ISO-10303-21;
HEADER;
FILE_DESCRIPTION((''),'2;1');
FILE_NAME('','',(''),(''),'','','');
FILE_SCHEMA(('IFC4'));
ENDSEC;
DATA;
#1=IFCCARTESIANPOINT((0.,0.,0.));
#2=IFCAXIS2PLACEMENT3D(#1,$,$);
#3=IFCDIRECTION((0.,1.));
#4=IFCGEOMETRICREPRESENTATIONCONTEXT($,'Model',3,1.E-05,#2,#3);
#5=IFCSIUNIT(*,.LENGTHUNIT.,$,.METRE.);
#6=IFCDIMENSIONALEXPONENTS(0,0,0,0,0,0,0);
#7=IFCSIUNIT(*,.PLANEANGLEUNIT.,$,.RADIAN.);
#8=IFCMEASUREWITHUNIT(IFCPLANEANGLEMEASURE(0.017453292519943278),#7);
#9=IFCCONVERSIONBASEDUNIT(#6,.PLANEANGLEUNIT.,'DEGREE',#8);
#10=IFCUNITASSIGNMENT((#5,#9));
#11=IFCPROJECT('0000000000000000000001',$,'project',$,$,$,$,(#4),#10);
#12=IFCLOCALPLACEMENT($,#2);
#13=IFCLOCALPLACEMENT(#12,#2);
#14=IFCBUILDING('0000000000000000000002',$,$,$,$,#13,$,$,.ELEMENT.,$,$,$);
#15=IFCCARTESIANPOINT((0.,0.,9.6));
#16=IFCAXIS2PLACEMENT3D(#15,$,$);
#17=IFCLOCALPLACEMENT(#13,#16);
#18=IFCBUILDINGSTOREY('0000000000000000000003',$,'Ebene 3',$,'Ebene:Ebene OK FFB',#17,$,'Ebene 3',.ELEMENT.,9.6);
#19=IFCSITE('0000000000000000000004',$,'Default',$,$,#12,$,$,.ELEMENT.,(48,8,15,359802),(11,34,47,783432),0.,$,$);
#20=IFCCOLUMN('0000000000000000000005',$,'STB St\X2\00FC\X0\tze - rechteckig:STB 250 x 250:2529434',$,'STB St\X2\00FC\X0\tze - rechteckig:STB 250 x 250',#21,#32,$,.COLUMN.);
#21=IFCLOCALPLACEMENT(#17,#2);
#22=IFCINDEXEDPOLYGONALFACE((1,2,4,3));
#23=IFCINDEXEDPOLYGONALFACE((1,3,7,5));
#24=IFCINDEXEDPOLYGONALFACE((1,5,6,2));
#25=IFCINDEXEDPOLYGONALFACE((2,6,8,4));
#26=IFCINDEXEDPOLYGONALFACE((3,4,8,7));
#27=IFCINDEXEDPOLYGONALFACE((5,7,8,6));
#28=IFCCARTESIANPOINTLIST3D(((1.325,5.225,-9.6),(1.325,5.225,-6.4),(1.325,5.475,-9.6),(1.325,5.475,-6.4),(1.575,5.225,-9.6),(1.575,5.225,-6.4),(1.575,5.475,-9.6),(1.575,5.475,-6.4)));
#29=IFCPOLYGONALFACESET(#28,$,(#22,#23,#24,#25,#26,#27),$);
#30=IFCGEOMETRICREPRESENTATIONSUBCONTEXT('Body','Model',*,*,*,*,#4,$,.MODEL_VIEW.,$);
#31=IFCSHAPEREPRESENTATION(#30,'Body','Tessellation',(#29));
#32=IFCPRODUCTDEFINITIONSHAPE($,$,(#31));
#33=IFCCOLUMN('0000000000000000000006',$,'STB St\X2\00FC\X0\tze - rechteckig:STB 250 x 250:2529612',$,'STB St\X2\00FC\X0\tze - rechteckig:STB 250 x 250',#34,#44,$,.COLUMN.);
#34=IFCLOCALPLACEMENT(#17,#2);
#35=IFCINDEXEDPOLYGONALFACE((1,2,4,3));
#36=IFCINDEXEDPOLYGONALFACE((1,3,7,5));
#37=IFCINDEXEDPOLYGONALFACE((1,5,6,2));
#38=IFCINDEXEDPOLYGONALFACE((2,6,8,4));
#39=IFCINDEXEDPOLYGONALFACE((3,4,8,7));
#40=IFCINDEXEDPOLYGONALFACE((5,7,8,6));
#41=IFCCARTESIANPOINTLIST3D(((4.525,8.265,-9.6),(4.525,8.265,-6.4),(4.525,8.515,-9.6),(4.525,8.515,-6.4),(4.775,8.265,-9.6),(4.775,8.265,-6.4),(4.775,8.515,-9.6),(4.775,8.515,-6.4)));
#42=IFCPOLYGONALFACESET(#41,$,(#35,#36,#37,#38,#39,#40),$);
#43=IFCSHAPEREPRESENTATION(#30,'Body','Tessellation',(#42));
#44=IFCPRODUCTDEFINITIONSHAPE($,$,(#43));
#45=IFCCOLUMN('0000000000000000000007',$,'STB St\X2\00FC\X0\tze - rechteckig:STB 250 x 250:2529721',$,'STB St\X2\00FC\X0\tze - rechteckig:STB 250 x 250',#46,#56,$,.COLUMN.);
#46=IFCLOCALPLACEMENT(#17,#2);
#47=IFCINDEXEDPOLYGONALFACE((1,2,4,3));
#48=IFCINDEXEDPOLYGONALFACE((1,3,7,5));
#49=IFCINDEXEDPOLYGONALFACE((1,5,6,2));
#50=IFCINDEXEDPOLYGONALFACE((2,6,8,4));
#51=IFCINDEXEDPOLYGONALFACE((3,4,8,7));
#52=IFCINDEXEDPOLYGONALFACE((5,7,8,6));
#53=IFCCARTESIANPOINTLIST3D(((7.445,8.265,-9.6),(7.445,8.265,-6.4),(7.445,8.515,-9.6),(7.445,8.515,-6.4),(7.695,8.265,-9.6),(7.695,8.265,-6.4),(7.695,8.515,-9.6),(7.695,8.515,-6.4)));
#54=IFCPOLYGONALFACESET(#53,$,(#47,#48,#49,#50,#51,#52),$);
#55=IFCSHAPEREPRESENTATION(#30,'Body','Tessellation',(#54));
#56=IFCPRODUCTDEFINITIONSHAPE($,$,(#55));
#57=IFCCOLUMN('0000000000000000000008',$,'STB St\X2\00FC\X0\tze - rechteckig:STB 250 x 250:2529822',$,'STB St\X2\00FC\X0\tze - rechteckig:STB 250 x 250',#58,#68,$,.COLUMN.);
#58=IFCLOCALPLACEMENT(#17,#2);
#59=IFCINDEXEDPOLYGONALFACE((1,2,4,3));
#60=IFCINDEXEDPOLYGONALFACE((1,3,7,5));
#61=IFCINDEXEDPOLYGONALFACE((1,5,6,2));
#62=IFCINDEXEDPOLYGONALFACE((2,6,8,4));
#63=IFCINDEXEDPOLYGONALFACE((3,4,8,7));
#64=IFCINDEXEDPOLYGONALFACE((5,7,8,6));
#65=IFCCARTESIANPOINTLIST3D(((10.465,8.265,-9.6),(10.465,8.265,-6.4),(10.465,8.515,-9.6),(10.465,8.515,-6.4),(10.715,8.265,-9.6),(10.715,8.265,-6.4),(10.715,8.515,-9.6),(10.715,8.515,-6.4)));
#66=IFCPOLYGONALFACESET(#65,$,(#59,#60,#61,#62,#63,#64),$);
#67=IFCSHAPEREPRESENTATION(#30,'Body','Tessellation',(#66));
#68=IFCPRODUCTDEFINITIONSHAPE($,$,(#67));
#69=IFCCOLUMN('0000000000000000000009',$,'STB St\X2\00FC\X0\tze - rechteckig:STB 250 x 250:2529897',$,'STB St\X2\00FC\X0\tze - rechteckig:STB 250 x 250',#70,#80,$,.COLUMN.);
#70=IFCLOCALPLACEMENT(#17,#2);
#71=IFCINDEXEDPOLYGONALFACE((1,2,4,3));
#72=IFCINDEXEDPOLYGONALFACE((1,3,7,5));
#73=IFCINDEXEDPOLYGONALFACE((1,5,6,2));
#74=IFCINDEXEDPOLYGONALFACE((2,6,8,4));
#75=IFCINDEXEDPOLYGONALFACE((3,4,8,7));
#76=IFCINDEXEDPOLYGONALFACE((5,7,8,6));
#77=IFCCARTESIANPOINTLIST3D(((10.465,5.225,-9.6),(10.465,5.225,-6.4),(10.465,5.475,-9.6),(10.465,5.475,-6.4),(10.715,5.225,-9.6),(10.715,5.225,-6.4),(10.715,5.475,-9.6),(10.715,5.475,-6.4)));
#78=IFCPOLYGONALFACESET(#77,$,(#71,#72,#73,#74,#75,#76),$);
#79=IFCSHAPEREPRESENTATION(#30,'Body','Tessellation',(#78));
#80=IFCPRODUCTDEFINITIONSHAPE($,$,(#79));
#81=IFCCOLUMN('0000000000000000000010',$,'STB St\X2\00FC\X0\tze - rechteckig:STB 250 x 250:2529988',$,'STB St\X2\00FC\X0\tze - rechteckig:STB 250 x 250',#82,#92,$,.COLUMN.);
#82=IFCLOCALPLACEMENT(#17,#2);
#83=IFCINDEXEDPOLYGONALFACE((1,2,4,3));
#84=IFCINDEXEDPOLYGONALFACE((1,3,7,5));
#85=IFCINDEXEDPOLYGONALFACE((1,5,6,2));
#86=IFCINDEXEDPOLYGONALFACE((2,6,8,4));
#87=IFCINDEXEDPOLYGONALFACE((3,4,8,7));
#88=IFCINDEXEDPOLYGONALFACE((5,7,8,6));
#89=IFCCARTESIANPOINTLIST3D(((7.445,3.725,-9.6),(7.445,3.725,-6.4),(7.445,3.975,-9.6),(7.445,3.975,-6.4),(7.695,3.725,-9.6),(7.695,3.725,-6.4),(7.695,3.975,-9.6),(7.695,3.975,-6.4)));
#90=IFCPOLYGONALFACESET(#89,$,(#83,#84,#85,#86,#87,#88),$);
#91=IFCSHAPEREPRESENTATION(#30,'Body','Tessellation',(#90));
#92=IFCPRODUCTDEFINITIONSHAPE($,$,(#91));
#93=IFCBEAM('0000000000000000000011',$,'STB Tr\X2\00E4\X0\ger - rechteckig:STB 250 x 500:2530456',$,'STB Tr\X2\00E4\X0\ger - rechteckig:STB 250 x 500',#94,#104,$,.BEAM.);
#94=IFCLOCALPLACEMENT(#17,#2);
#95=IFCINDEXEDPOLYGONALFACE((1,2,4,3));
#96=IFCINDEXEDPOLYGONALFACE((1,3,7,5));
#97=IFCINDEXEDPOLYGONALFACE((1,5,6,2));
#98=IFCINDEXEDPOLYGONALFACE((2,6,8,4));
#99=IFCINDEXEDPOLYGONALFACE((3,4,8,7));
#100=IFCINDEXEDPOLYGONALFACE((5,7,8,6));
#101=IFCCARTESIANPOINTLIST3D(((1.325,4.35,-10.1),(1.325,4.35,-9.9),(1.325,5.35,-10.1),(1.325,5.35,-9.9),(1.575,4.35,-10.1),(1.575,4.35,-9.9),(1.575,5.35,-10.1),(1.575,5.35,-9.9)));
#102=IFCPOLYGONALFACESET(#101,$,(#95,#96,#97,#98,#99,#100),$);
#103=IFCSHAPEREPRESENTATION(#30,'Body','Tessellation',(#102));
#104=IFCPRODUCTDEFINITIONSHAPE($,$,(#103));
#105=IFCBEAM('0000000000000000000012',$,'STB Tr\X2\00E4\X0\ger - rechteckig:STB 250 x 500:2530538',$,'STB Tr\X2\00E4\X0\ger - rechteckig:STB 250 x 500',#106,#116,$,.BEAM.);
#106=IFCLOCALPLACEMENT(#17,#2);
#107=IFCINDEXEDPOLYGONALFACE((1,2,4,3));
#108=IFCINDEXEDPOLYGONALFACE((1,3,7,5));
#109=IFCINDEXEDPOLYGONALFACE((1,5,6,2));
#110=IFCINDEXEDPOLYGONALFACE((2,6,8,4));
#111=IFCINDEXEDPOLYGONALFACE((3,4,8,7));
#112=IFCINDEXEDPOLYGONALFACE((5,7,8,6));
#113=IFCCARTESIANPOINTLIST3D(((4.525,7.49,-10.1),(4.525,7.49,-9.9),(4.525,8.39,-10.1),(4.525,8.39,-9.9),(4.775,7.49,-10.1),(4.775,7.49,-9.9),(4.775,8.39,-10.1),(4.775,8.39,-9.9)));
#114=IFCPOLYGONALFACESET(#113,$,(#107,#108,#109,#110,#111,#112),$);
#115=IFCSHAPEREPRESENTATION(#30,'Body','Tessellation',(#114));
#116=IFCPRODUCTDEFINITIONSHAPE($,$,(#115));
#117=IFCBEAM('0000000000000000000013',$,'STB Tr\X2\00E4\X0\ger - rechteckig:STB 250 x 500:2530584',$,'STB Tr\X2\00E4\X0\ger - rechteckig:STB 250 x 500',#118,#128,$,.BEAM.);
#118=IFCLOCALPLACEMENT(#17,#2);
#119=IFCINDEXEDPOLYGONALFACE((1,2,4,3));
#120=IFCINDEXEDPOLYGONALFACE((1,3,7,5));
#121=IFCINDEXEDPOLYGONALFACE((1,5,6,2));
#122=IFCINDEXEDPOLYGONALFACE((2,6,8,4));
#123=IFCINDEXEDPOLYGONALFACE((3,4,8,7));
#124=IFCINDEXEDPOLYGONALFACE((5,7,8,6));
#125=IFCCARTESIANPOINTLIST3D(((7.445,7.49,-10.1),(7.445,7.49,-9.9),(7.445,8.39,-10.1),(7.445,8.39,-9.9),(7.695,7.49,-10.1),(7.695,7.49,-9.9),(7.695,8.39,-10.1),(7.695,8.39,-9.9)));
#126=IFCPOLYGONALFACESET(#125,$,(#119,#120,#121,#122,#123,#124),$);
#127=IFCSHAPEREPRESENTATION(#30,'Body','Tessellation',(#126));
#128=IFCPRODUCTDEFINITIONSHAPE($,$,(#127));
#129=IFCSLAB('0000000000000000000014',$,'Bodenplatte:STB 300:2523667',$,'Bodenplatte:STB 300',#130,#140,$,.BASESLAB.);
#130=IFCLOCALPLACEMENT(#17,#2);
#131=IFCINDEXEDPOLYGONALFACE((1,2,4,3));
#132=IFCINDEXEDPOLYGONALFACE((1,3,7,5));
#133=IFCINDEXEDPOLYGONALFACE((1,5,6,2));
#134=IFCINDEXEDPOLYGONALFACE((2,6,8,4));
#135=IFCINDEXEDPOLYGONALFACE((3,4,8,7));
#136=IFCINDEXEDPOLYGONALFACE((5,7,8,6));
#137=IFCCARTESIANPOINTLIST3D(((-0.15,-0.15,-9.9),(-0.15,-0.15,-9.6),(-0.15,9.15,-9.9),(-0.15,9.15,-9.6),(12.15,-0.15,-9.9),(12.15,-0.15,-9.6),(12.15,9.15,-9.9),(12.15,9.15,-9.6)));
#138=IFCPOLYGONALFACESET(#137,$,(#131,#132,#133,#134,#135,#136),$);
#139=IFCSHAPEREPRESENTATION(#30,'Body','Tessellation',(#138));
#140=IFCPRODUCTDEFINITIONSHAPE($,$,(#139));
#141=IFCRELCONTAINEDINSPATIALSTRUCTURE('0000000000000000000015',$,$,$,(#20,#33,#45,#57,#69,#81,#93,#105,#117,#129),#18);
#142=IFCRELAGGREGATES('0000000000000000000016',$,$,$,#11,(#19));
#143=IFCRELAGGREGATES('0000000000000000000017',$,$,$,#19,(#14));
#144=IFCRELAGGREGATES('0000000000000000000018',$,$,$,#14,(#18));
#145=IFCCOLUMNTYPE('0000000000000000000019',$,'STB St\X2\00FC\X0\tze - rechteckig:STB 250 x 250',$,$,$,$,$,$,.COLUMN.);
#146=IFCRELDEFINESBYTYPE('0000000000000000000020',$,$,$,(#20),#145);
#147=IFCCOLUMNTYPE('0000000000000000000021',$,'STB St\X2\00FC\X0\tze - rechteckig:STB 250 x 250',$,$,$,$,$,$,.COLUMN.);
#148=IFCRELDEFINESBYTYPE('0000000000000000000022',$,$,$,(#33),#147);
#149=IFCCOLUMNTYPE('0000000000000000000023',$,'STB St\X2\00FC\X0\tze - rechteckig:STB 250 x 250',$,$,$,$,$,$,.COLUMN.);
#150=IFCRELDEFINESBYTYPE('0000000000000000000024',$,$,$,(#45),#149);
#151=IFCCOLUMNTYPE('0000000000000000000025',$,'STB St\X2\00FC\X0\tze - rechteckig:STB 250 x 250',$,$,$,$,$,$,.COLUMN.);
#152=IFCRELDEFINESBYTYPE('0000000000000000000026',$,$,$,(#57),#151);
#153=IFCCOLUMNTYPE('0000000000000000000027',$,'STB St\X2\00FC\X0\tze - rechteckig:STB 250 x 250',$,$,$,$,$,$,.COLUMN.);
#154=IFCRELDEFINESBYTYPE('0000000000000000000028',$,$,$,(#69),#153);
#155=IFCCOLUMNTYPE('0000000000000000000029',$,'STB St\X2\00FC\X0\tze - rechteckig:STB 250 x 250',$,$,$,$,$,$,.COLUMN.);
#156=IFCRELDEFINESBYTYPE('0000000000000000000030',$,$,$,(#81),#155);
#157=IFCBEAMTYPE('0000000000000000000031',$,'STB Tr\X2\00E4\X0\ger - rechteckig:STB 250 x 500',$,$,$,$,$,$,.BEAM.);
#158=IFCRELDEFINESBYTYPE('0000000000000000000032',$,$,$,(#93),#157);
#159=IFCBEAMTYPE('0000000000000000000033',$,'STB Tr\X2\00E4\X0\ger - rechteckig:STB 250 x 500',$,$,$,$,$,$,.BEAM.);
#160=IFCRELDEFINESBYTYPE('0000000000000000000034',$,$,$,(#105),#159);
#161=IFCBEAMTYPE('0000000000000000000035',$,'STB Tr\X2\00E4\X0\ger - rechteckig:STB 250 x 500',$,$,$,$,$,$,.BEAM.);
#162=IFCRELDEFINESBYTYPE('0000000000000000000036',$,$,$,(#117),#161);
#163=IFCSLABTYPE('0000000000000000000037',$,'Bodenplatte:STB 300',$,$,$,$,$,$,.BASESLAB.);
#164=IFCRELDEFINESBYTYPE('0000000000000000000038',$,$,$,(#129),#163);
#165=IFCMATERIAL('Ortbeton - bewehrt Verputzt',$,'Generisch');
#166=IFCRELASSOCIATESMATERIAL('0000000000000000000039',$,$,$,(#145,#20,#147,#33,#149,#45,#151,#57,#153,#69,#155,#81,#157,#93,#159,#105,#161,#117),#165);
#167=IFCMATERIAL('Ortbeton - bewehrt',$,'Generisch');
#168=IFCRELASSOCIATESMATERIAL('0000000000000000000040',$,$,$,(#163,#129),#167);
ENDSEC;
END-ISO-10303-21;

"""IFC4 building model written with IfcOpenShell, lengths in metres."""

from ifc_helpers import new_model, entity, si_unit, converted_unit, direction, frame, origin, place, context, subcontext, project, spatial, indexed_curve, outline, extrude, source, transform, mapped, material, type_object, type_shapes, element, save


model = new_model("IFC4")

# Units and contexts
model_context = context("Model", 3, precision=1e-05, world=origin(), true_north=direction((0.0, 1.0)))
body_context = subcontext(model_context, "Body", "Model", "MODEL_VIEW")
ifc_project = project(units=[si_unit("LENGTHUNIT", "METRE"), converted_unit("PLANEANGLEUNIT", "DEGREE", entity("IfcPlaneAngleMeasure", 0.017453292519943278), si_unit("PLANEANGLEUNIT", "RADIAN"), dimensions=[0, 0, 0, 0, 0, 0, 0])], contexts=[model_context])

# Site, building, storey
site_placement = place(None, origin())
site = spatial("IfcSite", under=ifc_project, at=site_placement, Name="Default", CompositionType="ELEMENT", RefLatitude=(48, 8, 15, 359802), RefLongitude=(11, 34, 47, 783432), RefElevation=0.0)
building_placement = place(site_placement, origin())
building = spatial("IfcBuilding", under=site, at=building_placement, CompositionType="ELEMENT")
storey_placement = place(building_placement, frame((0.0, 0.0, 9.6)))
storey = spatial("IfcBuildingStorey", under=building, at=storey_placement, Name="Ebene 3", ObjectType="Ebene:Ebene OK FFB", LongName="Ebene 3", CompositionType="ELEMENT", Elevation=9.6)

# Columns
ifc_material_1 = material(Name="Ortbeton - bewehrt Verputzt", Category="Generisch")
column_type_1 = type_object("IfcColumnType", Name="STB Stütze - rechteckig:STB 250 x 250", PredefinedType="COLUMN", material=ifc_material_1)
shared_shape_1 = source(origin(), body_context, "Body", "SweptSolid", [
    extrude(outline(indexed_curve([(-0.125, -0.125), (0.125, -0.125), (0.125, 0.125), (-0.125, 0.125), (-0.125, -0.125)], self_intersect=False)), frame((1.45, 5.35, 0.0), z_axis=(0.0, 0.0, 1.0), x_axis=(-1.0, 0.0, 0.0)), (0.0, 0.0, 1.0), 3.2),
])
type_shapes(column_type_1, [shared_shape_1])
column_1_placement = place(storey_placement, frame((0.0, 0.0, -9.6)))
element("IfcColumn", 1, at=column_1_placement, inside=storey, type_object=column_type_1, material=ifc_material_1, Name="STB Stütze - rechteckig:STB 250 x 250:2529434", ObjectType="STB Stütze - rechteckig:STB 250 x 250", PredefinedType="COLUMN", context=body_context, shape_type="MappedRepresentation", body=[
    mapped(shared_shape_1, transform((0.0, 0.0, 0.0), scale=1.0)),
])
column_type_2 = type_object("IfcColumnType", Name="STB Stütze - rechteckig:STB 250 x 250", PredefinedType="COLUMN", material=ifc_material_1)
shared_shape_2 = source(origin(), body_context, "Body", "SweptSolid", [
    extrude(outline(indexed_curve([(-0.125, -0.125), (0.125, -0.125), (0.125, 0.125), (-0.125, 0.125), (-0.125, -0.125)], self_intersect=False)), frame((4.65, 8.39, 0.0), z_axis=(0.0, 0.0, 1.0), x_axis=(-1.0, 0.0, 0.0)), (0.0, 0.0, 1.0), 3.2),
])
type_shapes(column_type_2, [shared_shape_2])
column_2_placement = place(storey_placement, frame((0.0, 0.0, -9.6)))
element("IfcColumn", 2, at=column_2_placement, inside=storey, type_object=column_type_2, material=ifc_material_1, Name="STB Stütze - rechteckig:STB 250 x 250:2529612", ObjectType="STB Stütze - rechteckig:STB 250 x 250", PredefinedType="COLUMN", context=body_context, shape_type="MappedRepresentation", body=[
    mapped(shared_shape_2, transform((0.0, 0.0, 0.0), scale=1.0)),
])
column_type_3 = type_object("IfcColumnType", Name="STB Stütze - rechteckig:STB 250 x 250", PredefinedType="COLUMN", material=ifc_material_1)
shared_shape_3 = source(origin(), body_context, "Body", "SweptSolid", [
    extrude(outline(indexed_curve([(-0.125, -0.125), (0.125, -0.125), (0.125, 0.125), (-0.125, 0.125), (-0.125, -0.125)], self_intersect=False)), frame((7.57, 8.39, 0.0), z_axis=(0.0, 0.0, 1.0), x_axis=(-1.0, 0.0, 0.0)), (0.0, 0.0, 1.0), 3.2),
])
type_shapes(column_type_3, [shared_shape_3])
column_3_placement = place(storey_placement, frame((0.0, 0.0, -9.6)))
element("IfcColumn", 3, at=column_3_placement, inside=storey, type_object=column_type_3, material=ifc_material_1, Name="STB Stütze - rechteckig:STB 250 x 250:2529721", ObjectType="STB Stütze - rechteckig:STB 250 x 250", PredefinedType="COLUMN", context=body_context, shape_type="MappedRepresentation", body=[
    mapped(shared_shape_3, transform((0.0, 0.0, 0.0), scale=1.0)),
])
column_type_4 = type_object("IfcColumnType", Name="STB Stütze - rechteckig:STB 250 x 250", PredefinedType="COLUMN", material=ifc_material_1)
shared_shape_4 = source(origin(), body_context, "Body", "SweptSolid", [
    extrude(outline(indexed_curve([(-0.125, -0.125), (0.125, -0.125), (0.125, 0.125), (-0.125, 0.125), (-0.125, -0.125)], self_intersect=False)), frame((10.59, 8.39, 0.0), z_axis=(0.0, 0.0, 1.0), x_axis=(-1.0, 0.0, 0.0)), (0.0, 0.0, 1.0), 3.2),
])
type_shapes(column_type_4, [shared_shape_4])
column_4_placement = place(storey_placement, frame((0.0, 0.0, -9.6)))
element("IfcColumn", 4, at=column_4_placement, inside=storey, type_object=column_type_4, material=ifc_material_1, Name="STB Stütze - rechteckig:STB 250 x 250:2529822", ObjectType="STB Stütze - rechteckig:STB 250 x 250", PredefinedType="COLUMN", context=body_context, shape_type="MappedRepresentation", body=[
    mapped(shared_shape_4, transform((0.0, 0.0, 0.0), scale=1.0)),
])
column_type_5 = type_object("IfcColumnType", Name="STB Stütze - rechteckig:STB 250 x 250", PredefinedType="COLUMN", material=ifc_material_1)
shared_shape_5 = source(origin(), body_context, "Body", "SweptSolid", [
    extrude(outline(indexed_curve([(-0.125, -0.125), (0.125, -0.125), (0.125, 0.125), (-0.125, 0.125), (-0.125, -0.125)], self_intersect=False)), frame((10.59, 5.35, 0.0), z_axis=(0.0, 0.0, 1.0), x_axis=(-1.0, 0.0, 0.0)), (0.0, 0.0, 1.0), 3.2),
])
type_shapes(column_type_5, [shared_shape_5])
column_5_placement = place(storey_placement, frame((0.0, 0.0, -9.6)))
element("IfcColumn", 5, at=column_5_placement, inside=storey, type_object=column_type_5, material=ifc_material_1, Name="STB Stütze - rechteckig:STB 250 x 250:2529897", ObjectType="STB Stütze - rechteckig:STB 250 x 250", PredefinedType="COLUMN", context=body_context, shape_type="MappedRepresentation", body=[
    mapped(shared_shape_5, transform((0.0, 0.0, 0.0), scale=1.0)),
])
column_type_6 = type_object("IfcColumnType", Name="STB Stütze - rechteckig:STB 250 x 250", PredefinedType="COLUMN", material=ifc_material_1)
shared_shape_6 = source(origin(), body_context, "Body", "SweptSolid", [
    extrude(outline(indexed_curve([(-0.125, -0.125), (0.125, -0.125), (0.125, 0.125), (-0.125, 0.125), (-0.125, -0.125)], self_intersect=False)), frame((7.57, 3.85, 0.0), z_axis=(0.0, 0.0, 1.0), x_axis=(-1.0, 0.0, 0.0)), (0.0, 0.0, 1.0), 3.2),
])
type_shapes(column_type_6, [shared_shape_6])
column_6_placement = place(storey_placement, frame((0.0, 0.0, -9.6)))
element("IfcColumn", 6, at=column_6_placement, inside=storey, type_object=column_type_6, material=ifc_material_1, Name="STB Stütze - rechteckig:STB 250 x 250:2529988", ObjectType="STB Stütze - rechteckig:STB 250 x 250", PredefinedType="COLUMN", context=body_context, shape_type="MappedRepresentation", body=[
    mapped(shared_shape_6, transform((0.0, 0.0, 0.0), scale=1.0)),
])

# Beams
beam_type_1 = type_object("IfcBeamType", Name="STB Träger - rechteckig:STB 250 x 500", PredefinedType="BEAM", material=ifc_material_1)
shared_shape_7 = source(origin(), body_context, "Body", "SweptSolid", [
    extrude(outline(indexed_curve([(-0.125, -0.1), (0.125, -0.1), (0.125, 0.1), (-0.125, 0.1), (-0.125, -0.1)], self_intersect=False)), frame((1.45, 5.35, -0.4), z_axis=(0.0, -1.0, 0.0), x_axis=(-1.0, 0.0, 0.0)), (0.0, 0.0, 1.0), 1.0),
])
type_shapes(beam_type_1, [shared_shape_7])
beam_1_placement = place(storey_placement, frame((0.0, 0.0, -9.6)))
element("IfcBeam", 7, at=beam_1_placement, inside=storey, type_object=beam_type_1, material=ifc_material_1, Name="STB Träger - rechteckig:STB 250 x 500:2530456", ObjectType="STB Träger - rechteckig:STB 250 x 500", PredefinedType="BEAM", context=body_context, shape_type="MappedRepresentation", body=[
    mapped(shared_shape_7, transform((0.0, 0.0, 0.0), scale=1.0)),
])
beam_type_2 = type_object("IfcBeamType", Name="STB Träger - rechteckig:STB 250 x 500", PredefinedType="BEAM", material=ifc_material_1)
shared_shape_8 = source(origin(), body_context, "Body", "SweptSolid", [
    extrude(outline(indexed_curve([(-0.125, -0.1), (0.125, -0.1), (0.125, 0.1), (-0.125, 0.1), (-0.125, -0.1)], self_intersect=False)), frame((4.65, 8.39, -0.4), z_axis=(0.0, -1.0, 0.0), x_axis=(-1.0, 0.0, 0.0)), (0.0, 0.0, 1.0), 0.9),
])
type_shapes(beam_type_2, [shared_shape_8])
beam_2_placement = place(storey_placement, frame((0.0, 0.0, -9.6)))
element("IfcBeam", 8, at=beam_2_placement, inside=storey, type_object=beam_type_2, material=ifc_material_1, Name="STB Träger - rechteckig:STB 250 x 500:2530538", ObjectType="STB Träger - rechteckig:STB 250 x 500", PredefinedType="BEAM", context=body_context, shape_type="MappedRepresentation", body=[
    mapped(shared_shape_8, transform((0.0, 0.0, 0.0), scale=1.0)),
])
beam_type_3 = type_object("IfcBeamType", Name="STB Träger - rechteckig:STB 250 x 500", PredefinedType="BEAM", material=ifc_material_1)
shared_shape_9 = source(origin(), body_context, "Body", "SweptSolid", [
    extrude(outline(indexed_curve([(-0.125, -0.1), (0.125, -0.1), (0.125, 0.1), (-0.125, 0.1), (-0.125, -0.1)], self_intersect=False)), frame((7.57, 8.39, -0.4), z_axis=(0.0, -1.0, 0.0), x_axis=(-1.0, 0.0, 0.0)), (0.0, 0.0, 1.0), 0.9),
])
type_shapes(beam_type_3, [shared_shape_9])
beam_3_placement = place(storey_placement, frame((0.0, 0.0, -9.6)))
element("IfcBeam", 9, at=beam_3_placement, inside=storey, type_object=beam_type_3, material=ifc_material_1, Name="STB Träger - rechteckig:STB 250 x 500:2530584", ObjectType="STB Träger - rechteckig:STB 250 x 500", PredefinedType="BEAM", context=body_context, shape_type="MappedRepresentation", body=[
    mapped(shared_shape_9, transform((0.0, 0.0, 0.0), scale=1.0)),
])

# Slab
ifc_material_2 = material(Name="Ortbeton - bewehrt", Category="Generisch")
slab_type = type_object("IfcSlabType", Name="Bodenplatte:STB 300", PredefinedType="BASESLAB", material=ifc_material_2)
slab_placement = place(storey_placement, origin())
element("IfcSlab", 10, at=slab_placement, inside=storey, type_object=slab_type, material=ifc_material_2, Name="Bodenplatte:STB 300:2523667", ObjectType="Bodenplatte:STB 300", PredefinedType="BASESLAB", context=body_context, shape_type="SweptSolid", body=[
    extrude(outline(indexed_curve([(-4.65, -6.15), (4.65, -6.15), (4.65, 6.15), (-4.65, 6.15), (-4.65, -6.15)], self_intersect=False)), frame((6.0, 4.5, -9.6), z_axis=(0.0, 0.0, -1.0), x_axis=(0.0, 1.0, 0.0)), (0.0, 0.0, 1.0), 0.3),
])

save(model, "model.ifc")
